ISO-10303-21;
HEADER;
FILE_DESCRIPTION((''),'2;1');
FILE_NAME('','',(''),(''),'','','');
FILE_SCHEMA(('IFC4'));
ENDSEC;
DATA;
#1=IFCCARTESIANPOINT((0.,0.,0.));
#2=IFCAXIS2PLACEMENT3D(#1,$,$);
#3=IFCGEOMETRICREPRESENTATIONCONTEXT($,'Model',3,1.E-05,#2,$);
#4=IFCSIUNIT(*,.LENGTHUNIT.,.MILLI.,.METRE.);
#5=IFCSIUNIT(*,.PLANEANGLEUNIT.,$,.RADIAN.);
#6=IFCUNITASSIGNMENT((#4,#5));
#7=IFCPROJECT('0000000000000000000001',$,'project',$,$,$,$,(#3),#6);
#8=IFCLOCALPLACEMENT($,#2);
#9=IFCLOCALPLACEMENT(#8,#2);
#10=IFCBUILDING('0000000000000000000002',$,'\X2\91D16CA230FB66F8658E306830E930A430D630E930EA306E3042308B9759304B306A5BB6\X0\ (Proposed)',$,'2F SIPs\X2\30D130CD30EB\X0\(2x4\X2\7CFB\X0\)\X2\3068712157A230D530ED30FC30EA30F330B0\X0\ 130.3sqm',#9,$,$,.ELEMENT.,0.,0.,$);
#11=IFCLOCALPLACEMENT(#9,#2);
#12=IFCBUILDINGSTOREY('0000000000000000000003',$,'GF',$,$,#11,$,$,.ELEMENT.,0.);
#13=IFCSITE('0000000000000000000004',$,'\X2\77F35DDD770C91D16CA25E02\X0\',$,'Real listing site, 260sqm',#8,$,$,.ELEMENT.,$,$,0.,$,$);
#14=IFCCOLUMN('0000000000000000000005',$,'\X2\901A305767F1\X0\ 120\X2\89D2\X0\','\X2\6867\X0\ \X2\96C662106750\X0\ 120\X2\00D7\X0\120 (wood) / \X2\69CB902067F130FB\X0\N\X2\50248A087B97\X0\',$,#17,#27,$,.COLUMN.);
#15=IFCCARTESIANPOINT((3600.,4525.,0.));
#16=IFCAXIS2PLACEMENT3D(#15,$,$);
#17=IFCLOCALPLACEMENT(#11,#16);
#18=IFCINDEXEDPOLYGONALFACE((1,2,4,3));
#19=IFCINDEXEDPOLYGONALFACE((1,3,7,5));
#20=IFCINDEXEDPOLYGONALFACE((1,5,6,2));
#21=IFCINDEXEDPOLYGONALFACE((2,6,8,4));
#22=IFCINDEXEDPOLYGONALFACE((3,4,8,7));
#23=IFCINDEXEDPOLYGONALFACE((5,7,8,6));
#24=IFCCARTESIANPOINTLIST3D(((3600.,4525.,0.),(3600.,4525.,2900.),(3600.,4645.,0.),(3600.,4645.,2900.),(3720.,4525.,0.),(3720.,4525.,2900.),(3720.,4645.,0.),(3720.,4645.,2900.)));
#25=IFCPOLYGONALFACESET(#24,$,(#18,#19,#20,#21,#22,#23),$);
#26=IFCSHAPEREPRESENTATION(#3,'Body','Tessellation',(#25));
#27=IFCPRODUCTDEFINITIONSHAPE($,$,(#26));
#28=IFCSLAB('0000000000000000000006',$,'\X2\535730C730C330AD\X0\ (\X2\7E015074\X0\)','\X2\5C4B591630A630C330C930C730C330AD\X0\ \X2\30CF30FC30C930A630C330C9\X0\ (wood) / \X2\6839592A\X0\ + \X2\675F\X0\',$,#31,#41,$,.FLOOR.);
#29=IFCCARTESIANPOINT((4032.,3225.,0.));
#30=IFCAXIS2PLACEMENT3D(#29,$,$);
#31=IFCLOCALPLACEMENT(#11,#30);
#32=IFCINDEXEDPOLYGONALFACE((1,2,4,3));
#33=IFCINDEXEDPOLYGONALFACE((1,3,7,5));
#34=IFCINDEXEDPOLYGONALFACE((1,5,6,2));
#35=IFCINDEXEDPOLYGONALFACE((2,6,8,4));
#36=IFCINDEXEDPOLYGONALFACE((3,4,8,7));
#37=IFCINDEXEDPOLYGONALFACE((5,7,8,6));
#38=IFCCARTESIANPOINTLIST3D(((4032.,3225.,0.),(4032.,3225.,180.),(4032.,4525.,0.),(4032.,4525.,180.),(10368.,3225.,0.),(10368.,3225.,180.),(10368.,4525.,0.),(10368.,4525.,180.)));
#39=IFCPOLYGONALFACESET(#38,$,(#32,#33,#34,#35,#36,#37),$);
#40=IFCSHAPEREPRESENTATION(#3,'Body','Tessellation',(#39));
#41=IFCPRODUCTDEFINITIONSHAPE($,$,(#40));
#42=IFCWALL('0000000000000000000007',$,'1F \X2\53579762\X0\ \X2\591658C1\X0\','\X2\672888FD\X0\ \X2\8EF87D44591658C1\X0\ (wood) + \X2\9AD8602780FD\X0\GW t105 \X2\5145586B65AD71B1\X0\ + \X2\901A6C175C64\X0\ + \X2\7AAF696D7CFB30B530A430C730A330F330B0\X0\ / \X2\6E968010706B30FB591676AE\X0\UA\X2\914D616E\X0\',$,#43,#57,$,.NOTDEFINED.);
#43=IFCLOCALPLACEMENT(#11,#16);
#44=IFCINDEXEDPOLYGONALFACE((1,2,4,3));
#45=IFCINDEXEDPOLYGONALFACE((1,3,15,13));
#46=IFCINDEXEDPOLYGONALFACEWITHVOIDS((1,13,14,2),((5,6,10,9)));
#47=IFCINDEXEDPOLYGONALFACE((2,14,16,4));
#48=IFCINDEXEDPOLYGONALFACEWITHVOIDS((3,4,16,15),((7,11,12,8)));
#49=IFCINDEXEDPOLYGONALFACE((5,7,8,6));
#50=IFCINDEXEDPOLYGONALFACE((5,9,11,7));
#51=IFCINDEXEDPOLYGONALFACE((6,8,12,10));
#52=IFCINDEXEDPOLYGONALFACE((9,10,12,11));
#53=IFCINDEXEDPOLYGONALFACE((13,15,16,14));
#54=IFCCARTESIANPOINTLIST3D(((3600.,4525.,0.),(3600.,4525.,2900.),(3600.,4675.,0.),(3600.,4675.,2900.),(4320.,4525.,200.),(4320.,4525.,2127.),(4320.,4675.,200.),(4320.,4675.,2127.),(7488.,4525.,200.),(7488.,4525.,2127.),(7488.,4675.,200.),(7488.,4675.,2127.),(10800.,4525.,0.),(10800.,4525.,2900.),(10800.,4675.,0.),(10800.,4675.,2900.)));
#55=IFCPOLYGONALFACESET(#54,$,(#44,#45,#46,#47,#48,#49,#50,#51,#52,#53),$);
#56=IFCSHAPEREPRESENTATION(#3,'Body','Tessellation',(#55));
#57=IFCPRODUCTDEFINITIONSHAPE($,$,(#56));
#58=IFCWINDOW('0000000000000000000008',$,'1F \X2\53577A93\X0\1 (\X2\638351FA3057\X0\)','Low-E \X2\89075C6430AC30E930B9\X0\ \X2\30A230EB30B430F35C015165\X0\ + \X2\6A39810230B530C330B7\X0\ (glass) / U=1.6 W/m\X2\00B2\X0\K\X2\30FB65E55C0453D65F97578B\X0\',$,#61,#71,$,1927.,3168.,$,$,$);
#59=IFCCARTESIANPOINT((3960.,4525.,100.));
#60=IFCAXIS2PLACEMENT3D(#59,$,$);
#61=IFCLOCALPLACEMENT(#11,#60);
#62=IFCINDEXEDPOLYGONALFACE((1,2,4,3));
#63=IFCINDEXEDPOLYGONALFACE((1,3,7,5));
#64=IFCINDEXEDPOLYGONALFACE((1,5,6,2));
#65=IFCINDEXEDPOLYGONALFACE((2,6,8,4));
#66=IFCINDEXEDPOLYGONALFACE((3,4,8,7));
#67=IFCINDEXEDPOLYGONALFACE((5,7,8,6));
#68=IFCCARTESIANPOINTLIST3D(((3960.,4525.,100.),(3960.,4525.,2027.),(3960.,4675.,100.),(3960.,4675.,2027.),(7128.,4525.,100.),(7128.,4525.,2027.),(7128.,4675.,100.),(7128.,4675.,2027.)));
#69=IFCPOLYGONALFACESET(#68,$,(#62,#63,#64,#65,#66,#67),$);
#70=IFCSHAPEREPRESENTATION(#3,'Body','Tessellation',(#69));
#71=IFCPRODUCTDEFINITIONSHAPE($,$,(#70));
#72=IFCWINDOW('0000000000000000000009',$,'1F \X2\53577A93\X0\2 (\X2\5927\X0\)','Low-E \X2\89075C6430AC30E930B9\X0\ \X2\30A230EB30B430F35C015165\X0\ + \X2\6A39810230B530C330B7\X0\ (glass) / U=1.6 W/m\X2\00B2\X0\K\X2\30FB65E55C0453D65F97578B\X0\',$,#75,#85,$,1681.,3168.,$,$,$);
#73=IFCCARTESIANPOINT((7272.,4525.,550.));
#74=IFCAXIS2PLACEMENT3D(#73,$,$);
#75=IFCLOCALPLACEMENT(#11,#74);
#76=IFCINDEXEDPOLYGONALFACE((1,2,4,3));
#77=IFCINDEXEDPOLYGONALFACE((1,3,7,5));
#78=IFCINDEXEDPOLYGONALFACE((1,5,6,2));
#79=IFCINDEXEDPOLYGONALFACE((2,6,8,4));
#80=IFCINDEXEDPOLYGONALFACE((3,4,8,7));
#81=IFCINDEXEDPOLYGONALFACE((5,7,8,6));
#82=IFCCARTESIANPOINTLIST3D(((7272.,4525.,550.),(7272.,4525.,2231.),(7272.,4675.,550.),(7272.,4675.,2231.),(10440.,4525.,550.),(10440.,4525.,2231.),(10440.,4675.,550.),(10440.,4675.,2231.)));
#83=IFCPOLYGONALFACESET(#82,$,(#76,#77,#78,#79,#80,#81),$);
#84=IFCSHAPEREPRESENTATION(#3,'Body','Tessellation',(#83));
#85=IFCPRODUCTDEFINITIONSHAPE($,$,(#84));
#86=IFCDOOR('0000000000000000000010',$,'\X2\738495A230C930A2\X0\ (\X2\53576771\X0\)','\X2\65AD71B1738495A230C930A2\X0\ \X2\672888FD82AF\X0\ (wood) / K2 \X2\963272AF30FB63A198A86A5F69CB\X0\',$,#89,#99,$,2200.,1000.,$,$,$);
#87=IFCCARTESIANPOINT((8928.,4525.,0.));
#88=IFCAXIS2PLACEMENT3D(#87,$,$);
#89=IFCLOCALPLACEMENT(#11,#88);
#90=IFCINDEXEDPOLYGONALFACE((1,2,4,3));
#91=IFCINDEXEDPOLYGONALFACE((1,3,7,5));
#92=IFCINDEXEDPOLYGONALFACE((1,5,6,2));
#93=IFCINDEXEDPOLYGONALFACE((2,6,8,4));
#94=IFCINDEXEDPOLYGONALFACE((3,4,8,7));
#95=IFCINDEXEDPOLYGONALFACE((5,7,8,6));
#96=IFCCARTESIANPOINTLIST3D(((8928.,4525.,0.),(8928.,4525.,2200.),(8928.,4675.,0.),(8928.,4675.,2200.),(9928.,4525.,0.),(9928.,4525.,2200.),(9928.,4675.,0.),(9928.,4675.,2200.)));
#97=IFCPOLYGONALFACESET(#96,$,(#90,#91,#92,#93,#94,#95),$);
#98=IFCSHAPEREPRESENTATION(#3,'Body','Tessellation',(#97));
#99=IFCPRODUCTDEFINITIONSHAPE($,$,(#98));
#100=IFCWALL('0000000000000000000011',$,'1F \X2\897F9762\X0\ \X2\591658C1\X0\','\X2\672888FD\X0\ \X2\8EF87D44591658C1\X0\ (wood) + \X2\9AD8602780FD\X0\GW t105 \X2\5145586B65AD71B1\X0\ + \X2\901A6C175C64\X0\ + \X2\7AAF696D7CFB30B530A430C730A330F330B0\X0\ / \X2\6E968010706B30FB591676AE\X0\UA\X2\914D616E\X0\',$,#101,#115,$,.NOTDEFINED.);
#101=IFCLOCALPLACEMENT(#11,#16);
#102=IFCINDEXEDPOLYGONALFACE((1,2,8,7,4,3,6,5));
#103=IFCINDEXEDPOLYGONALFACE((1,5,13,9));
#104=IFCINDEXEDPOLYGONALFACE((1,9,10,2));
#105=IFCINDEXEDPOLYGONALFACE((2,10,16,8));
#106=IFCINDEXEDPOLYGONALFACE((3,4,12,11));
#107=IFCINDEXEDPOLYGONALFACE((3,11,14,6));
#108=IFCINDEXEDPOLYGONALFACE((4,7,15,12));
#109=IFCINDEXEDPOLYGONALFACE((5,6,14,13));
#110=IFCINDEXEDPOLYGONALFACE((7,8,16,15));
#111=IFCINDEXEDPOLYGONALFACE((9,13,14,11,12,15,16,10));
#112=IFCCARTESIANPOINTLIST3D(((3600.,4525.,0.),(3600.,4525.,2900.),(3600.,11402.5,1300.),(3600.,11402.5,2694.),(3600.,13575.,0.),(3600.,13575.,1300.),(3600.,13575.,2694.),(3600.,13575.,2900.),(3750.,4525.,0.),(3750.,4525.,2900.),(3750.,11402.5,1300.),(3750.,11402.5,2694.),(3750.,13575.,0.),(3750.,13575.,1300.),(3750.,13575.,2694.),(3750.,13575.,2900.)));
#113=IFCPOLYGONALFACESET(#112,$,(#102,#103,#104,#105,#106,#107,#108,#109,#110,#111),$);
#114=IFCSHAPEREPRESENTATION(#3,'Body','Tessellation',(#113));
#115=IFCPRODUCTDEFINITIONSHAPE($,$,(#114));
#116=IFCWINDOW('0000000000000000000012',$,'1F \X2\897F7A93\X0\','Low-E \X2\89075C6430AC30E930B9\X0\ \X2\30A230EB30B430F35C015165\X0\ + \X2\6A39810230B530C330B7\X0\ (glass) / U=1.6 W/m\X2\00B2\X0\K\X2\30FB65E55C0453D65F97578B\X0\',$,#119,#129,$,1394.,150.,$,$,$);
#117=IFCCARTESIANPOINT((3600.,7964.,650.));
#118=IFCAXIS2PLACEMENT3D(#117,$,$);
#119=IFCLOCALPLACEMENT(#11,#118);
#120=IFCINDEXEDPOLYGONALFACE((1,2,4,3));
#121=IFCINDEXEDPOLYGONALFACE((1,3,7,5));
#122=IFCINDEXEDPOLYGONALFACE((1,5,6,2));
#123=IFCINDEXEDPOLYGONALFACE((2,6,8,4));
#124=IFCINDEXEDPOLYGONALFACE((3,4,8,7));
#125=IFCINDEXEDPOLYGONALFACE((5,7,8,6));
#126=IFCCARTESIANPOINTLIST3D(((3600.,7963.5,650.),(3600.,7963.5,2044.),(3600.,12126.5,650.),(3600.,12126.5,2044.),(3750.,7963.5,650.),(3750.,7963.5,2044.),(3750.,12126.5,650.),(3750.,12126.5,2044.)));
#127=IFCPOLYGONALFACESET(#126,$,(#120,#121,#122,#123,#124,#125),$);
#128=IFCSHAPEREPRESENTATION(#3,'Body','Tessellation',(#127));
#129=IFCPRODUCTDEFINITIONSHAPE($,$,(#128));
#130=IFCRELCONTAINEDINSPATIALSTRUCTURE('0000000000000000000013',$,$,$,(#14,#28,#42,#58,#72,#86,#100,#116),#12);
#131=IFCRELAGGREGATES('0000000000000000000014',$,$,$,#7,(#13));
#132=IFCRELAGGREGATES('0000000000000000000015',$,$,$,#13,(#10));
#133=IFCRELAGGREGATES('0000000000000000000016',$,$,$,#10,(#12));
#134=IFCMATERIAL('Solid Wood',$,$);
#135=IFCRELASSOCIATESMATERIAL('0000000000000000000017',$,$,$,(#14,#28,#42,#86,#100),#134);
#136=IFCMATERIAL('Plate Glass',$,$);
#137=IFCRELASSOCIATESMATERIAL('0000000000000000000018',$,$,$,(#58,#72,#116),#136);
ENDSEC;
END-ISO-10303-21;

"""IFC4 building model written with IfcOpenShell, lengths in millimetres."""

from ifc_helpers import new_model, si_unit, frame, frame_2d, origin, place, context, project, spatial, rectangle, extrude, material, element, fill, save


model = new_model("IFC4")

# Units and contexts
model_context = context("Model", 3, precision=1e-05, world=origin())
ifc_project = project(units=[si_unit("LENGTHUNIT", "METRE", prefix="MILLI"), si_unit("PLANEANGLEUNIT", "RADIAN")], contexts=[model_context])

# Site, building, storey
site_placement = place(None, origin())
site = spatial("IfcSite", under=ifc_project, at=site_placement, Name="石川県金沢市", ObjectType="Real listing site, 260sqm", CompositionType="ELEMENT", RefElevation=0.0)
building_placement = place(site_placement, origin())
building = spatial("IfcBuilding", under=site, at=building_placement, Name="金沢・書斎とライブラリのある静かな家 (Proposed)", ObjectType="2F SIPsパネル(2x4系)と無垢フローリング 130.3sqm", CompositionType="ELEMENT", ElevationOfRefHeight=0.0, ElevationOfTerrain=0.0)
storey_placement = place(building_placement, origin())
storey = spatial("IfcBuildingStorey", under=building, at=storey_placement, Name="GF", CompositionType="ELEMENT", Elevation=0.0)

# Column
ifc_material_1 = material(Name="Solid Wood")
column_placement = place(storey_placement, frame((3600.0, 4525.0, 0.0)))
element("IfcColumn", 1, at=column_placement, inside=storey, material=ifc_material_1, Name="通し柱 120角", Description="桧 集成材 120×120 (wood) / 構造柱・N値計算", PredefinedType="COLUMN", context=model_context, shape_type="SweptSolid", body=[
    extrude(rectangle(XDim=120.0, YDim=120.0, at=frame_2d((60.0, 60.0))), frame((3600.0, 4525.0, 0.0)), (0.0, 0.0, 1.0), 2900.0),
])

# Slab
slab_1_placement = place(storey_placement, frame((4032.0, 3225.0, 0.0)))
element("IfcSlab", 2, at=slab_1_placement, inside=storey, material=ifc_material_1, Name="南デッキ (縁側)", Description="屋外ウッドデッキ ハードウッド (wood) / 根太 + 束", PredefinedType="FLOOR", context=model_context, shape_type="SweptSolid", body=[
    extrude(rectangle(XDim=6336.0, YDim=1300.0, at=frame_2d((3168.0, 650.0))), frame((4032.0, 3225.0, 0.0)), (0.0, 0.0, 1.0), 180.0),
])

# Wall, openings, windows, door
wall_1_placement = place(storey_placement, frame((3600.0, 4525.0, 0.0)))
wall_1 = element("IfcWall", 3, at=wall_1_placement, inside=storey, material=ifc_material_1, Name="1F 南面 外壁", Description="木製 軸組外壁 (wood) + 高性能GW t105 充填断熱 + 通気層 + 窯業系サイディング / 準耐火・外皮UA配慮", PredefinedType="NOTDEFINED", context=model_context, shape_type="SweptSolid", body=[
    extrude(rectangle(XDim=7200.0, YDim=150.0, at=frame_2d((3600.0, 75.0))), frame((3600.0, 4525.0, 0.0)), (0.0, 0.0, 1.0), 2900.0),
])
opening_1_placement = place(storey_placement, frame((3960.0, 4525.0, 100.0)))
opening_1 = element("IfcOpeningElement", 4, at=opening_1_placement, cuts=wall_1, PredefinedType="NOTDEFINED", context=model_context, shape_type="SweptSolid", body=[
    extrude(rectangle(XDim=3168.0, YDim=150.0, at=frame_2d((1584.0, 75.0))), frame((3960.0, 4525.0, 100.0)), (0.0, 0.0, 1.0), 1927.0),
])
opening_2_placement = place(storey_placement, frame((7272.0, 4525.0, 550.0)))
opening_2 = element("IfcOpeningElement", 5, at=opening_2_placement, cuts=wall_1, PredefinedType="NOTDEFINED", context=model_context, shape_type="SweptSolid", body=[
    extrude(rectangle(XDim=3168.0, YDim=150.0, at=frame_2d((1584.0, 75.0))), frame((7272.0, 4525.0, 550.0)), (0.0, 0.0, 1.0), 1681.0),
])
opening_3_placement = place(storey_placement, frame((8928.0, 4525.0, 0.0)))
opening_3 = element("IfcOpeningElement", 6, at=opening_3_placement, cuts=wall_1, PredefinedType="NOTDEFINED", context=model_context, shape_type="SweptSolid", body=[
    extrude(rectangle(XDim=1000.0, YDim=150.0, at=frame_2d((500.0, 75.0))), frame((8928.0, 4525.0, 0.0)), (0.0, 0.0, 1.0), 2200.0),
])
ifc_material_2 = material(Name="Plate Glass")
window_1_placement = place(storey_placement, frame((3960.0, 4525.0, 100.0)))
window_1 = element("IfcWindow", 7, at=window_1_placement, inside=storey, material=ifc_material_2, Name="1F 南窓1 (掃出し)", Description="Low-E 複層ガラス アルゴン封入 + 樹脂サッシ (glass) / U=1.6 W/m²K・日射取得型", OverallHeight=1927.0, OverallWidth=3168.0, context=model_context, shape_type="SweptSolid", body=[
    extrude(rectangle(XDim=3168.0, YDim=150.0, at=frame_2d((1584.0, 75.0))), frame((3960.0, 4525.0, 100.0)), (0.0, 0.0, 1.0), 1927.0),
])
fill(opening_1, window_1)
window_2_placement = place(storey_placement, frame((7272.0, 4525.0, 550.0)))
window_2 = element("IfcWindow", 8, at=window_2_placement, inside=storey, material=ifc_material_2, Name="1F 南窓2 (大)", Description="Low-E 複層ガラス アルゴン封入 + 樹脂サッシ (glass) / U=1.6 W/m²K・日射取得型", OverallHeight=1681.0, OverallWidth=3168.0, context=model_context, shape_type="SweptSolid", body=[
    extrude(rectangle(XDim=3168.0, YDim=150.0, at=frame_2d((1584.0, 75.0))), frame((7272.0, 4525.0, 550.0)), (0.0, 0.0, 1.0), 1681.0),
])
fill(opening_2, window_2)
door_placement = place(storey_placement, frame((8928.0, 4525.0, 0.0)))
door = element("IfcDoor", 9, at=door_placement, inside=storey, material=ifc_material_1, Name="玄関ドア (南東)", Description="断熱玄関ドア 木製芯 (wood) / K2 防犯・採風機構", OverallHeight=2200.0, OverallWidth=1000.0, context=model_context, shape_type="SweptSolid", body=[
    extrude(rectangle(XDim=1000.0, YDim=150.0, at=frame_2d((500.0, 75.0))), frame((8928.0, 4525.0, 0.0)), (0.0, 0.0, 1.0), 2200.0),
])
fill(opening_3, door)

# Wall, opening, window
wall_2_placement = place(storey_placement, frame((3600.0, 4525.0, 0.0)))
wall_2 = element("IfcWall", 10, at=wall_2_placement, inside=storey, material=ifc_material_1, Name="1F 西面 外壁", Description="木製 軸組外壁 (wood) + 高性能GW t105 充填断熱 + 通気層 + 窯業系サイディング / 準耐火・外皮UA配慮", PredefinedType="NOTDEFINED", context=model_context, shape_type="SweptSolid", body=[
    extrude(rectangle(XDim=150.0, YDim=9050.0, at=frame_2d((75.0, 4525.0))), frame((3600.0, 4525.0, 0.0)), (0.0, 0.0, 1.0), 2900.0),
])
opening_4_placement = place(storey_placement, frame((3600.0, 7964.0, 650.0)))
opening_4 = element("IfcOpeningElement", 11, at=opening_4_placement, cuts=wall_2, PredefinedType="NOTDEFINED", context=model_context, shape_type="SweptSolid", body=[
    extrude(rectangle(XDim=150.0, YDim=4163.0, at=frame_2d((75.0, 2081.0))), frame((3600.0, 7964.0, 650.0)), (0.0, 0.0, 1.0), 1394.0),
])
window_3_placement = place(storey_placement, frame((3600.0, 7964.0, 650.0)))
window_3 = element("IfcWindow", 12, at=window_3_placement, inside=storey, material=ifc_material_2, Name="1F 西窓", Description="Low-E 複層ガラス アルゴン封入 + 樹脂サッシ (glass) / U=1.6 W/m²K・日射取得型", OverallHeight=1394.0, OverallWidth=150.0, context=model_context, shape_type="SweptSolid", body=[
    extrude(rectangle(XDim=150.0, YDim=4163.0, at=frame_2d((75.0, 2081.0))), frame((3600.0, 7964.0, 650.0)), (0.0, 0.0, 1.0), 1394.0),
])
fill(opening_4, window_3)

save(model, "model.ifc")
